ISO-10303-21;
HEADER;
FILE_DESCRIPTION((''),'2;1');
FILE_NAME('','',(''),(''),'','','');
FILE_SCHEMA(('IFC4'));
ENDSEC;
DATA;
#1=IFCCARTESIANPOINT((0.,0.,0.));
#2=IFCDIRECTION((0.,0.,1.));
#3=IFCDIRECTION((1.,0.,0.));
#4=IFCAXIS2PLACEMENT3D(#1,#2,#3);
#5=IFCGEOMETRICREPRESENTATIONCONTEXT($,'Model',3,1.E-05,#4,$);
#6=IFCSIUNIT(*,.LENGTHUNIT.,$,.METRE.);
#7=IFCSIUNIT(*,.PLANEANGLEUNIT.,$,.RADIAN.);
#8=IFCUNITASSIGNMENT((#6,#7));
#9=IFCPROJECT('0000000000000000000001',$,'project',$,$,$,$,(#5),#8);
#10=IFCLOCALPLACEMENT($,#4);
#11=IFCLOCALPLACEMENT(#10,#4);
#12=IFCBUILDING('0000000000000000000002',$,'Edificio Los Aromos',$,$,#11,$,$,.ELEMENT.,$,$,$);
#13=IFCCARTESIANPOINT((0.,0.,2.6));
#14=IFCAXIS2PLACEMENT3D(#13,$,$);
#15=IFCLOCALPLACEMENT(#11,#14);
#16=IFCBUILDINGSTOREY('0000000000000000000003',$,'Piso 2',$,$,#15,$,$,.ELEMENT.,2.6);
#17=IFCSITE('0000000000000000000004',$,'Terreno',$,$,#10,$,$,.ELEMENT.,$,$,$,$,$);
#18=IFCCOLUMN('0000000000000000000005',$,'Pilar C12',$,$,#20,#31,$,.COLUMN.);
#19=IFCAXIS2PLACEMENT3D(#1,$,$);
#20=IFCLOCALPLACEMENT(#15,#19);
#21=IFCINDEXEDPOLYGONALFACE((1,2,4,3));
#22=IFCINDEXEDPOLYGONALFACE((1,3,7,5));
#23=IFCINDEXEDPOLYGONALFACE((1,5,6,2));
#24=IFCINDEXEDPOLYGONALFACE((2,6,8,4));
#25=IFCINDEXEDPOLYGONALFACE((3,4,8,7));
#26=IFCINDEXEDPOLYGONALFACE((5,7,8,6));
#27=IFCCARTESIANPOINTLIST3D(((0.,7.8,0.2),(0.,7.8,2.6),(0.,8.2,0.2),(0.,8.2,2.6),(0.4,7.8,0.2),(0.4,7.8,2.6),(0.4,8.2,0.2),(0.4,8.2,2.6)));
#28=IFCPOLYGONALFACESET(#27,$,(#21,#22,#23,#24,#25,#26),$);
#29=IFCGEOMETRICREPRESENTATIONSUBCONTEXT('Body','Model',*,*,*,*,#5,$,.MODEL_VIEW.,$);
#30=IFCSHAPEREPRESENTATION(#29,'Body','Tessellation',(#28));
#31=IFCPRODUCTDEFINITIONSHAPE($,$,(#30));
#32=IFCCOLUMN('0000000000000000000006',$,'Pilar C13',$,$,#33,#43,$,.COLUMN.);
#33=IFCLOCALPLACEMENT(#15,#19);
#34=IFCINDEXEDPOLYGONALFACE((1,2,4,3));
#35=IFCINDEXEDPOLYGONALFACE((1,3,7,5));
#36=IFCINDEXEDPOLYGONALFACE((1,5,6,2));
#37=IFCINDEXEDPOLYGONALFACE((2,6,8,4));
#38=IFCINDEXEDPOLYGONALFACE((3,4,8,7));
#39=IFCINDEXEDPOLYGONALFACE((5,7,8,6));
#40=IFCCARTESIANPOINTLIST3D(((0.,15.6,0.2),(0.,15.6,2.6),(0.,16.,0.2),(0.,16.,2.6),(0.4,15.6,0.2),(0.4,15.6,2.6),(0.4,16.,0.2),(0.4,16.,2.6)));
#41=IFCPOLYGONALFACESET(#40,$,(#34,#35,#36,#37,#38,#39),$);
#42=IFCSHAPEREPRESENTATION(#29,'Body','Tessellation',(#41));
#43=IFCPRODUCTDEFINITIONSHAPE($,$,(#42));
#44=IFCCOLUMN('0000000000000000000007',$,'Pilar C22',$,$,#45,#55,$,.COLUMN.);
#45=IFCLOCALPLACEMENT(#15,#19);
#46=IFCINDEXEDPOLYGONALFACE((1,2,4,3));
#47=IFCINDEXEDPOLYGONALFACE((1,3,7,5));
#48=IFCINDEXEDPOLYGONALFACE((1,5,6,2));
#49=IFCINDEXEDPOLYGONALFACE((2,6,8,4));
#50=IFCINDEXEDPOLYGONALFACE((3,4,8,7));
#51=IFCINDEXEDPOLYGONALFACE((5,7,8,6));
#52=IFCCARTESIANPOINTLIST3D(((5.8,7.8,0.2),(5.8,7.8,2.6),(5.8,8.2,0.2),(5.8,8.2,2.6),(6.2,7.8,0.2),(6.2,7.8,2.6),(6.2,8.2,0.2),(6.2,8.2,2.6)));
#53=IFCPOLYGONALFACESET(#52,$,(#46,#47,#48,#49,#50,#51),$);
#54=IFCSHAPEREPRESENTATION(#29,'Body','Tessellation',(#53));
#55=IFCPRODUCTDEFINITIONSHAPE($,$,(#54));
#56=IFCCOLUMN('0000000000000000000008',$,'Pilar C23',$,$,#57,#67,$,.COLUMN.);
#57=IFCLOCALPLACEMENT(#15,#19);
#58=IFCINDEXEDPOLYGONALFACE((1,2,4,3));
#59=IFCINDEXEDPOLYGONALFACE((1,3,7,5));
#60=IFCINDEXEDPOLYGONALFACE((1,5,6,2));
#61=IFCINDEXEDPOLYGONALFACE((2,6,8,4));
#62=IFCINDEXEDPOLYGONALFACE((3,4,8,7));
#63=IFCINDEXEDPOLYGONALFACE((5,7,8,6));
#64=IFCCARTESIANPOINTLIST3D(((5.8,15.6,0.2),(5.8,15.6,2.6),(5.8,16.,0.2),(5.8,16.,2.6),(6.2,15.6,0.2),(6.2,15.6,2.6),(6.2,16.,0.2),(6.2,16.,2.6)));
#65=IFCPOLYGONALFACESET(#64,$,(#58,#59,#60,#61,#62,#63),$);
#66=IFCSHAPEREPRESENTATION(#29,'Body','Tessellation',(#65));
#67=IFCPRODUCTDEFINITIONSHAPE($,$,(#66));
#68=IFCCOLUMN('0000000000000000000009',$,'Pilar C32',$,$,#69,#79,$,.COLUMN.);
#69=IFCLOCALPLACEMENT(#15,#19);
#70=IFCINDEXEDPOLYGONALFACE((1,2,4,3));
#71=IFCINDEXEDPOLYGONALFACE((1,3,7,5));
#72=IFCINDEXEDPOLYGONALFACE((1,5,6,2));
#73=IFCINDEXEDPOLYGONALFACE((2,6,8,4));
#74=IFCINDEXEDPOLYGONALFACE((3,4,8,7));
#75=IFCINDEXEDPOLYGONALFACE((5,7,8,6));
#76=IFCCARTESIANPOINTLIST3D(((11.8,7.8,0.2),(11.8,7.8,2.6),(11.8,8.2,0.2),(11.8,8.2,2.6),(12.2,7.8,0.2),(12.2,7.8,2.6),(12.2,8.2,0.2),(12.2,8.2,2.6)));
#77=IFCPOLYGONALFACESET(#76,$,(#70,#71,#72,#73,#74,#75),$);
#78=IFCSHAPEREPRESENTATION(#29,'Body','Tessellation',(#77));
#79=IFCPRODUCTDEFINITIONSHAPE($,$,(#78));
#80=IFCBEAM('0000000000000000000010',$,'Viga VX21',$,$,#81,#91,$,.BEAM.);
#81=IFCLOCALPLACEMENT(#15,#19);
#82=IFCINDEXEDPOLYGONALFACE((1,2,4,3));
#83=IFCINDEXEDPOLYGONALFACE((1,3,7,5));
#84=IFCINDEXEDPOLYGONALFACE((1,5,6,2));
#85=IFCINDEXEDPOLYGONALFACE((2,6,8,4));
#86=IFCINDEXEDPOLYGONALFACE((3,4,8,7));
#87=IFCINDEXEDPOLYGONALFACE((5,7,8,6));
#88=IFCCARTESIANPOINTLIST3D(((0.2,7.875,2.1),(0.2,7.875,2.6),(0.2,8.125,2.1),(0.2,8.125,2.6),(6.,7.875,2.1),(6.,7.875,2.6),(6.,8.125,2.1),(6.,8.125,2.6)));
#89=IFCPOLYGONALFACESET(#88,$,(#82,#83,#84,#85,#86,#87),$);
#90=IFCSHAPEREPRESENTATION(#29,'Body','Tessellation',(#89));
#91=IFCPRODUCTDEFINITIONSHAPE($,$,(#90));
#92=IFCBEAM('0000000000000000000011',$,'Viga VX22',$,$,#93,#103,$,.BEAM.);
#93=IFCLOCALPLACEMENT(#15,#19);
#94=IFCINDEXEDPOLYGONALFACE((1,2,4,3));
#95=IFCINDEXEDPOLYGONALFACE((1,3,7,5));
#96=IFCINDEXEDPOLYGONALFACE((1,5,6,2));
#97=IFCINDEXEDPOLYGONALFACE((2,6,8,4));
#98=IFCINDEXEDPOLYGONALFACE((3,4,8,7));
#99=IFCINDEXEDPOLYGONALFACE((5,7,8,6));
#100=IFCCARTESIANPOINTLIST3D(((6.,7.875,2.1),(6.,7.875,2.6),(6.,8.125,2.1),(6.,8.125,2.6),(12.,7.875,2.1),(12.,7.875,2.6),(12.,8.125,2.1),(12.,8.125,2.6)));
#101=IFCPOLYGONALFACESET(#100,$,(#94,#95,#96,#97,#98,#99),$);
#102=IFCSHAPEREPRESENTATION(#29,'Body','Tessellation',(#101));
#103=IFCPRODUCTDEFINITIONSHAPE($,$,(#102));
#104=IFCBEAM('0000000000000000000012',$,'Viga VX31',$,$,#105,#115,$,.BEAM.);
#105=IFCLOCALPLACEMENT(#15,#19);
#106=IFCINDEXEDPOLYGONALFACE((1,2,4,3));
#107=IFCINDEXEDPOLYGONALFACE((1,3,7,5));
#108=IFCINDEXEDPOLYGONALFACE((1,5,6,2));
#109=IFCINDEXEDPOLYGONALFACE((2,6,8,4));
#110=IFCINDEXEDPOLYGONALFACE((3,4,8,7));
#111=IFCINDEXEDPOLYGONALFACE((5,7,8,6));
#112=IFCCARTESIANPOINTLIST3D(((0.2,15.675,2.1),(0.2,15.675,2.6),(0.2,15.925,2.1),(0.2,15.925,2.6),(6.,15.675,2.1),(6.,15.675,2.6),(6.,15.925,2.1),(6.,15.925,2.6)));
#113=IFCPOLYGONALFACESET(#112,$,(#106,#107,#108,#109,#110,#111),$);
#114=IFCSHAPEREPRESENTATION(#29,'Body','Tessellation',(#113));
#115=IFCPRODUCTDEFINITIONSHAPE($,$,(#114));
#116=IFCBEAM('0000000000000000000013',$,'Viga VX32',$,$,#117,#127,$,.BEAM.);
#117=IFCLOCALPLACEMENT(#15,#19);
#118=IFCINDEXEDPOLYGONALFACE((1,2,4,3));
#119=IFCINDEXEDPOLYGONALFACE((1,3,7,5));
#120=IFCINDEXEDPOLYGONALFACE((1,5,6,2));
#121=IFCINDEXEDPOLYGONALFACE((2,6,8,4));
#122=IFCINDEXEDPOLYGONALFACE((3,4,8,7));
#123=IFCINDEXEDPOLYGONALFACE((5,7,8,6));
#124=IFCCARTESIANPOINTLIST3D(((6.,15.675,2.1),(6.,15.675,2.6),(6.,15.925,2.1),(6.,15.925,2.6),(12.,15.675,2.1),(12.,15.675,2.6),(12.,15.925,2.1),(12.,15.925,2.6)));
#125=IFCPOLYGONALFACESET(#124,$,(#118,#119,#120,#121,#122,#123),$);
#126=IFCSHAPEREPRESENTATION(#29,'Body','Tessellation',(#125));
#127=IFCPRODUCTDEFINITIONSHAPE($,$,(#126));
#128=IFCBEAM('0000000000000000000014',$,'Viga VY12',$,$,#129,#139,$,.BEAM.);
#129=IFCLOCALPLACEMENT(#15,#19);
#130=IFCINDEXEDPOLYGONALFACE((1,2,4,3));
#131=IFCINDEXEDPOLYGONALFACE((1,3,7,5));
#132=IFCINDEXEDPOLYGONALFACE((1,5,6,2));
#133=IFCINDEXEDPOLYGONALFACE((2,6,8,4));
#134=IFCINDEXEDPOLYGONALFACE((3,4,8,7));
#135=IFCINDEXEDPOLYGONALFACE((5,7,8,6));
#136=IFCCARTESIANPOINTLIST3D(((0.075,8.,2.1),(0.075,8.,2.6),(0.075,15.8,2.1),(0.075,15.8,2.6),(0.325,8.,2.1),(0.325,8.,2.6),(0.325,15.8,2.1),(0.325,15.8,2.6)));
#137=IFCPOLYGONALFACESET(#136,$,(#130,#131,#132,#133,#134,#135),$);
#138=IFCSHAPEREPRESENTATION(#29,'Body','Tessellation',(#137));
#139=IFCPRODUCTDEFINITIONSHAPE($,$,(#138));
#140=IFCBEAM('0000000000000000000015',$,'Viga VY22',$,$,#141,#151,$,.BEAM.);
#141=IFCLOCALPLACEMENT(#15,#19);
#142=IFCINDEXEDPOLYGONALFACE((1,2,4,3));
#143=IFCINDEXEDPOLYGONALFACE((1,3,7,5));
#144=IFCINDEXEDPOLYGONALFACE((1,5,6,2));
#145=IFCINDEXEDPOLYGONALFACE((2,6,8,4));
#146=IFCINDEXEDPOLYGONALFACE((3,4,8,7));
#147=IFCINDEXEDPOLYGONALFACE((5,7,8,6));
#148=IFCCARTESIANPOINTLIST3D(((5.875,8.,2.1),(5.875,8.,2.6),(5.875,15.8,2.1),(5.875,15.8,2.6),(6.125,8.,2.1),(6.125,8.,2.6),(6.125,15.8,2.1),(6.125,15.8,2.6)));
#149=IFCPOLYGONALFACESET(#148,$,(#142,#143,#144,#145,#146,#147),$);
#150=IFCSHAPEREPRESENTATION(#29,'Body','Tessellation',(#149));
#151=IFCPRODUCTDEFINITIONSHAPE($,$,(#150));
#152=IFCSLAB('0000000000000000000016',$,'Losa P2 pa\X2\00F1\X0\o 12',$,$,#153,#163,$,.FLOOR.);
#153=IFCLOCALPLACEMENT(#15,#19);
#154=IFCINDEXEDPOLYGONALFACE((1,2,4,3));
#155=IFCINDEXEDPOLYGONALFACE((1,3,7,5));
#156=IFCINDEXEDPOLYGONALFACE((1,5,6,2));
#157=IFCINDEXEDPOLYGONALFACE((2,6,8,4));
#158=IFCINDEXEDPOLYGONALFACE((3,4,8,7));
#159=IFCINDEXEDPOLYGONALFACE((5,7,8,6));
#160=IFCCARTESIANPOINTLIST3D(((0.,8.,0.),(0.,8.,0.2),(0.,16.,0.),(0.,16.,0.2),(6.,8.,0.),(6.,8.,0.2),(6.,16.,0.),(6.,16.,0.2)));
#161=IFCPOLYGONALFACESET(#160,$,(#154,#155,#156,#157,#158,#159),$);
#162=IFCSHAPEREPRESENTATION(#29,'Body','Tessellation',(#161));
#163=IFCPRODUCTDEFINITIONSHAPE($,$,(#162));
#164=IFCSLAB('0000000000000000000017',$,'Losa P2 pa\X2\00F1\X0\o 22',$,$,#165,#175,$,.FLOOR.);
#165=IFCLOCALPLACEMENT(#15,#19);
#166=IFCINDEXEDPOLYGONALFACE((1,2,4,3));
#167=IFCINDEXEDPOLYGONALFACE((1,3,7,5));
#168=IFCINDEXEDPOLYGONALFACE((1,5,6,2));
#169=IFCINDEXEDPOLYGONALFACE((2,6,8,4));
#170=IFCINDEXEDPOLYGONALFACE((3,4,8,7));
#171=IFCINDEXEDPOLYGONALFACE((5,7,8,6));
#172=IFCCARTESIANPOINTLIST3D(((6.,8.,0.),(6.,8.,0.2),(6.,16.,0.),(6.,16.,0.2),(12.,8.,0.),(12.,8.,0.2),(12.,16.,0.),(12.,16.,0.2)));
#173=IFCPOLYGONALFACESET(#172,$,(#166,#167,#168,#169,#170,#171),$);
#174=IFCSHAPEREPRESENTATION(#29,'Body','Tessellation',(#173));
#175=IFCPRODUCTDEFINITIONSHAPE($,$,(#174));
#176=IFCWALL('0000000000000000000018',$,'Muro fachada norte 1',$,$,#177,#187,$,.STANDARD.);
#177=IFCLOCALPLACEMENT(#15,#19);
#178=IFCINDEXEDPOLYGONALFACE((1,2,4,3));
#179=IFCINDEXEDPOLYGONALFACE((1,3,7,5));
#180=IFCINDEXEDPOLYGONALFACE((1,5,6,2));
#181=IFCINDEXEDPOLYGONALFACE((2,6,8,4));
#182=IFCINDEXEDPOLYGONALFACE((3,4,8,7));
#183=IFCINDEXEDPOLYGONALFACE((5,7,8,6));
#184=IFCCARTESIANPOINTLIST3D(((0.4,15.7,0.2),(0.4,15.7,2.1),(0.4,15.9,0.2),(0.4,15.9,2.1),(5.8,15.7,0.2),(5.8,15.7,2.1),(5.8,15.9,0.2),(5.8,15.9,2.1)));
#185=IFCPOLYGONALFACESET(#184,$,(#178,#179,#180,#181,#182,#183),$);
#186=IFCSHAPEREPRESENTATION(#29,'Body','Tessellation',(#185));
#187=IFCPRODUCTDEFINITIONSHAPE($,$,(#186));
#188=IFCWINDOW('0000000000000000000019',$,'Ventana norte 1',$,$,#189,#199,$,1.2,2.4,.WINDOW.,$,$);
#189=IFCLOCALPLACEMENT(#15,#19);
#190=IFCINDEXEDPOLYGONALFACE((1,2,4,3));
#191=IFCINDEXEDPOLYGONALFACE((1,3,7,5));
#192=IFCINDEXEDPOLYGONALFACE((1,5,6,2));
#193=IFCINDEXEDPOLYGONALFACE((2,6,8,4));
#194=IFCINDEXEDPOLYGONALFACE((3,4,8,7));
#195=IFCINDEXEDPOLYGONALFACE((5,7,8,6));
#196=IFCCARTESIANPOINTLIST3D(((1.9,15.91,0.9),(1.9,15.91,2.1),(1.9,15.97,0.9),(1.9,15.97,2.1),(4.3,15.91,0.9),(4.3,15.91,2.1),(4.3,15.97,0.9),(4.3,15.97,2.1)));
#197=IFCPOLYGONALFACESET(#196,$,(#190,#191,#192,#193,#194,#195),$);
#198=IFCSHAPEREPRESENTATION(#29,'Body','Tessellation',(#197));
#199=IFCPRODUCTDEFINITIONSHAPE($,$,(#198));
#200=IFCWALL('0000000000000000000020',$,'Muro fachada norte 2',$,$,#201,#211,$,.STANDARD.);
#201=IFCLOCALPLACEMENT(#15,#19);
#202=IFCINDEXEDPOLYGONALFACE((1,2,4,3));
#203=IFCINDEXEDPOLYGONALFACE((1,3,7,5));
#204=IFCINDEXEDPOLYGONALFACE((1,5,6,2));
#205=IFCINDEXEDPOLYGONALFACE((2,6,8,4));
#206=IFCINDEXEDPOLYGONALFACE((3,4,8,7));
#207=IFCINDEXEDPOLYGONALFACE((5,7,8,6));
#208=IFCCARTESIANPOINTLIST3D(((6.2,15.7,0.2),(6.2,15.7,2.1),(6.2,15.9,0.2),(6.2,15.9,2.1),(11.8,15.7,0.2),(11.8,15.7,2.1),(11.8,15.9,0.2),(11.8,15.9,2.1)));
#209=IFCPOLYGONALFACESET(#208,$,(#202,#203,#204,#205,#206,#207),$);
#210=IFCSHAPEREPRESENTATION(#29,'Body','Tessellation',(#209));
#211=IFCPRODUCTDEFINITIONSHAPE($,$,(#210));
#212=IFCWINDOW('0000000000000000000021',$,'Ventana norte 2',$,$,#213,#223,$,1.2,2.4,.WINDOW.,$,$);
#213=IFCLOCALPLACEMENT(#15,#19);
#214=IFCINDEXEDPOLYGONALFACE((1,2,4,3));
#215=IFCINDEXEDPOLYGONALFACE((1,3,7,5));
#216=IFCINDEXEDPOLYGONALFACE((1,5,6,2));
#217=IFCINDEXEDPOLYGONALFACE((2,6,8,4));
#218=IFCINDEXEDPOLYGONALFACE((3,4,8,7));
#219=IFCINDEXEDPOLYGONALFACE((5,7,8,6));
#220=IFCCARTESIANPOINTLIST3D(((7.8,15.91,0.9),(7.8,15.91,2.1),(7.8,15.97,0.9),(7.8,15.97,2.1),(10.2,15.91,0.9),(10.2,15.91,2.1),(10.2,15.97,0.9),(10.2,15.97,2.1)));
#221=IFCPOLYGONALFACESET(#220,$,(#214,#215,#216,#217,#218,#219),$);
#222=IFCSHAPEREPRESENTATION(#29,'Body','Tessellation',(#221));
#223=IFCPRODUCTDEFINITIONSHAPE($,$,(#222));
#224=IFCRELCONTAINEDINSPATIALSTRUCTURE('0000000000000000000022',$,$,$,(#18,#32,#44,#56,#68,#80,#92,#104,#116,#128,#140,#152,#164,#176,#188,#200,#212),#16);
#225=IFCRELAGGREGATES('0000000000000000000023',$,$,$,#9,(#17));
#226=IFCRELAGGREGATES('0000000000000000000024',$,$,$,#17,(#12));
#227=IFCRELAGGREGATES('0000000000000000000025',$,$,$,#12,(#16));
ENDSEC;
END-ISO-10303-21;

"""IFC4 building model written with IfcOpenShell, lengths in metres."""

from ifc_helpers import new_model, si_unit, frame, frame_2d, origin_with_axes, place, context, subcontext, project, spatial, rectangle, extrude, element, save


model = new_model("IFC4")

# Units and contexts
model_context = context("Model", 3, precision=1e-05, world=origin_with_axes())
body_context = subcontext(model_context, "Body", "Model", "MODEL_VIEW")
ifc_project = project(units=[si_unit("LENGTHUNIT", "METRE"), si_unit("PLANEANGLEUNIT", "RADIAN")], contexts=[model_context])

# Site, building, storey
site_placement = place(None, origin_with_axes())
site = spatial("IfcSite", under=ifc_project, at=site_placement, Name="Terreno", CompositionType="ELEMENT")
building_placement = place(site_placement, origin_with_axes())
building = spatial("IfcBuilding", under=site, at=building_placement, Name="Edificio Los Aromos", CompositionType="ELEMENT")
storey_placement = place(building_placement, frame((0.0, 0.0, 2.6)))
storey = spatial("IfcBuildingStorey", under=building, at=storey_placement, Name="Piso 2", CompositionType="ELEMENT", Elevation=2.6)

# Columns
for number, where, name in (
    (1, (0.0, 7.8, 0.2), "Pilar C12"),
    (2, (0.0, 15.6, 0.2), "Pilar C13"),
    (3, (5.8, 7.8, 0.2), "Pilar C22"),
    (4, (5.8, 15.6, 0.2), "Pilar C23"),
    (5, (11.8, 7.8, 0.2), "Pilar C32"),
):
    element("IfcColumn", number, at=place(storey_placement, frame(where)), inside=storey, Name=name, PredefinedType="COLUMN", context=body_context, shape_type="SweptSolid", body=[
        extrude(rectangle(XDim=0.4, YDim=0.4, at=frame_2d((0.2, 0.2))), origin_with_axes(), (0.0, 0.0, 1.0), 2.4),
    ])

# Beams
beam_1_placement = place(storey_placement, frame((0.2, 7.875, 2.1)))
element("IfcBeam", 6, at=beam_1_placement, inside=storey, Name="Viga VX21", PredefinedType="BEAM", context=body_context, shape_type="SweptSolid", body=[
    extrude(rectangle(XDim=5.8, YDim=0.25, at=frame_2d((2.9, 0.125))), origin_with_axes(), (0.0, 0.0, 1.0), 0.5),
])
beam_2_placement = place(storey_placement, frame((6.0, 7.875, 2.1)))
element("IfcBeam", 7, at=beam_2_placement, inside=storey, Name="Viga VX22", PredefinedType="BEAM", context=body_context, shape_type="SweptSolid", body=[
    extrude(rectangle(XDim=6.0, YDim=0.25, at=frame_2d((3.0, 0.125))), origin_with_axes(), (0.0, 0.0, 1.0), 0.5),
])
beam_3_placement = place(storey_placement, frame((0.2, 15.675, 2.1)))
element("IfcBeam", 8, at=beam_3_placement, inside=storey, Name="Viga VX31", PredefinedType="BEAM", context=body_context, shape_type="SweptSolid", body=[
    extrude(rectangle(XDim=5.8, YDim=0.25, at=frame_2d((2.9, 0.125))), origin_with_axes(), (0.0, 0.0, 1.0), 0.5),
])
beam_4_placement = place(storey_placement, frame((6.0, 15.675, 2.1)))
element("IfcBeam", 9, at=beam_4_placement, inside=storey, Name="Viga VX32", PredefinedType="BEAM", context=body_context, shape_type="SweptSolid", body=[
    extrude(rectangle(XDim=6.0, YDim=0.25, at=frame_2d((3.0, 0.125))), origin_with_axes(), (0.0, 0.0, 1.0), 0.5),
])
for number, where, name in (
    (10, (0.075, 8.0, 2.1), "Viga VY12"),
    (11, (5.875, 8.0, 2.1), "Viga VY22"),
):
    element("IfcBeam", number, at=place(storey_placement, frame(where)), inside=storey, Name=name, PredefinedType="BEAM", context=body_context, shape_type="SweptSolid", body=[
        extrude(rectangle(XDim=0.25, YDim=7.8, at=frame_2d((0.125, 3.9))), origin_with_axes(), (0.0, 0.0, 1.0), 0.5),
    ])

# Slabs
for number, where, name in (
    (12, (0.0, 8.0, 0.0), "Losa P2 paño 12"),
    (13, (6.0, 8.0, 0.0), "Losa P2 paño 22"),
):
    element("IfcSlab", number, at=place(storey_placement, frame(where)), inside=storey, Name=name, PredefinedType="FLOOR", context=body_context, shape_type="SweptSolid", body=[
        extrude(rectangle(XDim=6.0, YDim=8.0, at=frame_2d((3.0, 4.0))), origin_with_axes(), (0.0, 0.0, 1.0), 0.2),
    ])

# Wall
wall_1_placement = place(storey_placement, frame((0.4, 15.7, 0.2)))
element("IfcWall", 14, at=wall_1_placement, inside=storey, Name="Muro fachada norte 1", PredefinedType="STANDARD", context=body_context, shape_type="SweptSolid", body=[
    extrude(rectangle(XDim=5.4, YDim=0.2, at=frame_2d((2.7, 0.1))), origin_with_axes(), (0.0, 0.0, 1.0), 1.9),
])

# Window
window_1_placement = place(storey_placement, frame((1.9, 15.91, 0.9)))
element("IfcWindow", 15, at=window_1_placement, inside=storey, Name="Ventana norte 1", OverallHeight=1.2, OverallWidth=2.4, PredefinedType="WINDOW", context=body_context, shape_type="SweptSolid", body=[
    extrude(rectangle(XDim=2.4, YDim=0.06, at=frame_2d((1.2, 0.03))), origin_with_axes(), (0.0, 0.0, 1.0), 1.2),
])

# Wall
wall_2_placement = place(storey_placement, frame((6.2, 15.7, 0.2)))
element("IfcWall", 16, at=wall_2_placement, inside=storey, Name="Muro fachada norte 2", PredefinedType="STANDARD", context=body_context, shape_type="SweptSolid", body=[
    extrude(rectangle(XDim=5.6, YDim=0.2, at=frame_2d((2.8, 0.1))), origin_with_axes(), (0.0, 0.0, 1.0), 1.9),
])

# Window
window_2_placement = place(storey_placement, frame((7.8, 15.91, 0.9)))
element("IfcWindow", 17, at=window_2_placement, inside=storey, Name="Ventana norte 2", OverallHeight=1.2, OverallWidth=2.4, PredefinedType="WINDOW", context=body_context, shape_type="SweptSolid", body=[
    extrude(rectangle(XDim=2.4, YDim=0.06, at=frame_2d((1.2, 0.03))), origin_with_axes(), (0.0, 0.0, 1.0), 1.2),
])

save(model, "model.ifc")
